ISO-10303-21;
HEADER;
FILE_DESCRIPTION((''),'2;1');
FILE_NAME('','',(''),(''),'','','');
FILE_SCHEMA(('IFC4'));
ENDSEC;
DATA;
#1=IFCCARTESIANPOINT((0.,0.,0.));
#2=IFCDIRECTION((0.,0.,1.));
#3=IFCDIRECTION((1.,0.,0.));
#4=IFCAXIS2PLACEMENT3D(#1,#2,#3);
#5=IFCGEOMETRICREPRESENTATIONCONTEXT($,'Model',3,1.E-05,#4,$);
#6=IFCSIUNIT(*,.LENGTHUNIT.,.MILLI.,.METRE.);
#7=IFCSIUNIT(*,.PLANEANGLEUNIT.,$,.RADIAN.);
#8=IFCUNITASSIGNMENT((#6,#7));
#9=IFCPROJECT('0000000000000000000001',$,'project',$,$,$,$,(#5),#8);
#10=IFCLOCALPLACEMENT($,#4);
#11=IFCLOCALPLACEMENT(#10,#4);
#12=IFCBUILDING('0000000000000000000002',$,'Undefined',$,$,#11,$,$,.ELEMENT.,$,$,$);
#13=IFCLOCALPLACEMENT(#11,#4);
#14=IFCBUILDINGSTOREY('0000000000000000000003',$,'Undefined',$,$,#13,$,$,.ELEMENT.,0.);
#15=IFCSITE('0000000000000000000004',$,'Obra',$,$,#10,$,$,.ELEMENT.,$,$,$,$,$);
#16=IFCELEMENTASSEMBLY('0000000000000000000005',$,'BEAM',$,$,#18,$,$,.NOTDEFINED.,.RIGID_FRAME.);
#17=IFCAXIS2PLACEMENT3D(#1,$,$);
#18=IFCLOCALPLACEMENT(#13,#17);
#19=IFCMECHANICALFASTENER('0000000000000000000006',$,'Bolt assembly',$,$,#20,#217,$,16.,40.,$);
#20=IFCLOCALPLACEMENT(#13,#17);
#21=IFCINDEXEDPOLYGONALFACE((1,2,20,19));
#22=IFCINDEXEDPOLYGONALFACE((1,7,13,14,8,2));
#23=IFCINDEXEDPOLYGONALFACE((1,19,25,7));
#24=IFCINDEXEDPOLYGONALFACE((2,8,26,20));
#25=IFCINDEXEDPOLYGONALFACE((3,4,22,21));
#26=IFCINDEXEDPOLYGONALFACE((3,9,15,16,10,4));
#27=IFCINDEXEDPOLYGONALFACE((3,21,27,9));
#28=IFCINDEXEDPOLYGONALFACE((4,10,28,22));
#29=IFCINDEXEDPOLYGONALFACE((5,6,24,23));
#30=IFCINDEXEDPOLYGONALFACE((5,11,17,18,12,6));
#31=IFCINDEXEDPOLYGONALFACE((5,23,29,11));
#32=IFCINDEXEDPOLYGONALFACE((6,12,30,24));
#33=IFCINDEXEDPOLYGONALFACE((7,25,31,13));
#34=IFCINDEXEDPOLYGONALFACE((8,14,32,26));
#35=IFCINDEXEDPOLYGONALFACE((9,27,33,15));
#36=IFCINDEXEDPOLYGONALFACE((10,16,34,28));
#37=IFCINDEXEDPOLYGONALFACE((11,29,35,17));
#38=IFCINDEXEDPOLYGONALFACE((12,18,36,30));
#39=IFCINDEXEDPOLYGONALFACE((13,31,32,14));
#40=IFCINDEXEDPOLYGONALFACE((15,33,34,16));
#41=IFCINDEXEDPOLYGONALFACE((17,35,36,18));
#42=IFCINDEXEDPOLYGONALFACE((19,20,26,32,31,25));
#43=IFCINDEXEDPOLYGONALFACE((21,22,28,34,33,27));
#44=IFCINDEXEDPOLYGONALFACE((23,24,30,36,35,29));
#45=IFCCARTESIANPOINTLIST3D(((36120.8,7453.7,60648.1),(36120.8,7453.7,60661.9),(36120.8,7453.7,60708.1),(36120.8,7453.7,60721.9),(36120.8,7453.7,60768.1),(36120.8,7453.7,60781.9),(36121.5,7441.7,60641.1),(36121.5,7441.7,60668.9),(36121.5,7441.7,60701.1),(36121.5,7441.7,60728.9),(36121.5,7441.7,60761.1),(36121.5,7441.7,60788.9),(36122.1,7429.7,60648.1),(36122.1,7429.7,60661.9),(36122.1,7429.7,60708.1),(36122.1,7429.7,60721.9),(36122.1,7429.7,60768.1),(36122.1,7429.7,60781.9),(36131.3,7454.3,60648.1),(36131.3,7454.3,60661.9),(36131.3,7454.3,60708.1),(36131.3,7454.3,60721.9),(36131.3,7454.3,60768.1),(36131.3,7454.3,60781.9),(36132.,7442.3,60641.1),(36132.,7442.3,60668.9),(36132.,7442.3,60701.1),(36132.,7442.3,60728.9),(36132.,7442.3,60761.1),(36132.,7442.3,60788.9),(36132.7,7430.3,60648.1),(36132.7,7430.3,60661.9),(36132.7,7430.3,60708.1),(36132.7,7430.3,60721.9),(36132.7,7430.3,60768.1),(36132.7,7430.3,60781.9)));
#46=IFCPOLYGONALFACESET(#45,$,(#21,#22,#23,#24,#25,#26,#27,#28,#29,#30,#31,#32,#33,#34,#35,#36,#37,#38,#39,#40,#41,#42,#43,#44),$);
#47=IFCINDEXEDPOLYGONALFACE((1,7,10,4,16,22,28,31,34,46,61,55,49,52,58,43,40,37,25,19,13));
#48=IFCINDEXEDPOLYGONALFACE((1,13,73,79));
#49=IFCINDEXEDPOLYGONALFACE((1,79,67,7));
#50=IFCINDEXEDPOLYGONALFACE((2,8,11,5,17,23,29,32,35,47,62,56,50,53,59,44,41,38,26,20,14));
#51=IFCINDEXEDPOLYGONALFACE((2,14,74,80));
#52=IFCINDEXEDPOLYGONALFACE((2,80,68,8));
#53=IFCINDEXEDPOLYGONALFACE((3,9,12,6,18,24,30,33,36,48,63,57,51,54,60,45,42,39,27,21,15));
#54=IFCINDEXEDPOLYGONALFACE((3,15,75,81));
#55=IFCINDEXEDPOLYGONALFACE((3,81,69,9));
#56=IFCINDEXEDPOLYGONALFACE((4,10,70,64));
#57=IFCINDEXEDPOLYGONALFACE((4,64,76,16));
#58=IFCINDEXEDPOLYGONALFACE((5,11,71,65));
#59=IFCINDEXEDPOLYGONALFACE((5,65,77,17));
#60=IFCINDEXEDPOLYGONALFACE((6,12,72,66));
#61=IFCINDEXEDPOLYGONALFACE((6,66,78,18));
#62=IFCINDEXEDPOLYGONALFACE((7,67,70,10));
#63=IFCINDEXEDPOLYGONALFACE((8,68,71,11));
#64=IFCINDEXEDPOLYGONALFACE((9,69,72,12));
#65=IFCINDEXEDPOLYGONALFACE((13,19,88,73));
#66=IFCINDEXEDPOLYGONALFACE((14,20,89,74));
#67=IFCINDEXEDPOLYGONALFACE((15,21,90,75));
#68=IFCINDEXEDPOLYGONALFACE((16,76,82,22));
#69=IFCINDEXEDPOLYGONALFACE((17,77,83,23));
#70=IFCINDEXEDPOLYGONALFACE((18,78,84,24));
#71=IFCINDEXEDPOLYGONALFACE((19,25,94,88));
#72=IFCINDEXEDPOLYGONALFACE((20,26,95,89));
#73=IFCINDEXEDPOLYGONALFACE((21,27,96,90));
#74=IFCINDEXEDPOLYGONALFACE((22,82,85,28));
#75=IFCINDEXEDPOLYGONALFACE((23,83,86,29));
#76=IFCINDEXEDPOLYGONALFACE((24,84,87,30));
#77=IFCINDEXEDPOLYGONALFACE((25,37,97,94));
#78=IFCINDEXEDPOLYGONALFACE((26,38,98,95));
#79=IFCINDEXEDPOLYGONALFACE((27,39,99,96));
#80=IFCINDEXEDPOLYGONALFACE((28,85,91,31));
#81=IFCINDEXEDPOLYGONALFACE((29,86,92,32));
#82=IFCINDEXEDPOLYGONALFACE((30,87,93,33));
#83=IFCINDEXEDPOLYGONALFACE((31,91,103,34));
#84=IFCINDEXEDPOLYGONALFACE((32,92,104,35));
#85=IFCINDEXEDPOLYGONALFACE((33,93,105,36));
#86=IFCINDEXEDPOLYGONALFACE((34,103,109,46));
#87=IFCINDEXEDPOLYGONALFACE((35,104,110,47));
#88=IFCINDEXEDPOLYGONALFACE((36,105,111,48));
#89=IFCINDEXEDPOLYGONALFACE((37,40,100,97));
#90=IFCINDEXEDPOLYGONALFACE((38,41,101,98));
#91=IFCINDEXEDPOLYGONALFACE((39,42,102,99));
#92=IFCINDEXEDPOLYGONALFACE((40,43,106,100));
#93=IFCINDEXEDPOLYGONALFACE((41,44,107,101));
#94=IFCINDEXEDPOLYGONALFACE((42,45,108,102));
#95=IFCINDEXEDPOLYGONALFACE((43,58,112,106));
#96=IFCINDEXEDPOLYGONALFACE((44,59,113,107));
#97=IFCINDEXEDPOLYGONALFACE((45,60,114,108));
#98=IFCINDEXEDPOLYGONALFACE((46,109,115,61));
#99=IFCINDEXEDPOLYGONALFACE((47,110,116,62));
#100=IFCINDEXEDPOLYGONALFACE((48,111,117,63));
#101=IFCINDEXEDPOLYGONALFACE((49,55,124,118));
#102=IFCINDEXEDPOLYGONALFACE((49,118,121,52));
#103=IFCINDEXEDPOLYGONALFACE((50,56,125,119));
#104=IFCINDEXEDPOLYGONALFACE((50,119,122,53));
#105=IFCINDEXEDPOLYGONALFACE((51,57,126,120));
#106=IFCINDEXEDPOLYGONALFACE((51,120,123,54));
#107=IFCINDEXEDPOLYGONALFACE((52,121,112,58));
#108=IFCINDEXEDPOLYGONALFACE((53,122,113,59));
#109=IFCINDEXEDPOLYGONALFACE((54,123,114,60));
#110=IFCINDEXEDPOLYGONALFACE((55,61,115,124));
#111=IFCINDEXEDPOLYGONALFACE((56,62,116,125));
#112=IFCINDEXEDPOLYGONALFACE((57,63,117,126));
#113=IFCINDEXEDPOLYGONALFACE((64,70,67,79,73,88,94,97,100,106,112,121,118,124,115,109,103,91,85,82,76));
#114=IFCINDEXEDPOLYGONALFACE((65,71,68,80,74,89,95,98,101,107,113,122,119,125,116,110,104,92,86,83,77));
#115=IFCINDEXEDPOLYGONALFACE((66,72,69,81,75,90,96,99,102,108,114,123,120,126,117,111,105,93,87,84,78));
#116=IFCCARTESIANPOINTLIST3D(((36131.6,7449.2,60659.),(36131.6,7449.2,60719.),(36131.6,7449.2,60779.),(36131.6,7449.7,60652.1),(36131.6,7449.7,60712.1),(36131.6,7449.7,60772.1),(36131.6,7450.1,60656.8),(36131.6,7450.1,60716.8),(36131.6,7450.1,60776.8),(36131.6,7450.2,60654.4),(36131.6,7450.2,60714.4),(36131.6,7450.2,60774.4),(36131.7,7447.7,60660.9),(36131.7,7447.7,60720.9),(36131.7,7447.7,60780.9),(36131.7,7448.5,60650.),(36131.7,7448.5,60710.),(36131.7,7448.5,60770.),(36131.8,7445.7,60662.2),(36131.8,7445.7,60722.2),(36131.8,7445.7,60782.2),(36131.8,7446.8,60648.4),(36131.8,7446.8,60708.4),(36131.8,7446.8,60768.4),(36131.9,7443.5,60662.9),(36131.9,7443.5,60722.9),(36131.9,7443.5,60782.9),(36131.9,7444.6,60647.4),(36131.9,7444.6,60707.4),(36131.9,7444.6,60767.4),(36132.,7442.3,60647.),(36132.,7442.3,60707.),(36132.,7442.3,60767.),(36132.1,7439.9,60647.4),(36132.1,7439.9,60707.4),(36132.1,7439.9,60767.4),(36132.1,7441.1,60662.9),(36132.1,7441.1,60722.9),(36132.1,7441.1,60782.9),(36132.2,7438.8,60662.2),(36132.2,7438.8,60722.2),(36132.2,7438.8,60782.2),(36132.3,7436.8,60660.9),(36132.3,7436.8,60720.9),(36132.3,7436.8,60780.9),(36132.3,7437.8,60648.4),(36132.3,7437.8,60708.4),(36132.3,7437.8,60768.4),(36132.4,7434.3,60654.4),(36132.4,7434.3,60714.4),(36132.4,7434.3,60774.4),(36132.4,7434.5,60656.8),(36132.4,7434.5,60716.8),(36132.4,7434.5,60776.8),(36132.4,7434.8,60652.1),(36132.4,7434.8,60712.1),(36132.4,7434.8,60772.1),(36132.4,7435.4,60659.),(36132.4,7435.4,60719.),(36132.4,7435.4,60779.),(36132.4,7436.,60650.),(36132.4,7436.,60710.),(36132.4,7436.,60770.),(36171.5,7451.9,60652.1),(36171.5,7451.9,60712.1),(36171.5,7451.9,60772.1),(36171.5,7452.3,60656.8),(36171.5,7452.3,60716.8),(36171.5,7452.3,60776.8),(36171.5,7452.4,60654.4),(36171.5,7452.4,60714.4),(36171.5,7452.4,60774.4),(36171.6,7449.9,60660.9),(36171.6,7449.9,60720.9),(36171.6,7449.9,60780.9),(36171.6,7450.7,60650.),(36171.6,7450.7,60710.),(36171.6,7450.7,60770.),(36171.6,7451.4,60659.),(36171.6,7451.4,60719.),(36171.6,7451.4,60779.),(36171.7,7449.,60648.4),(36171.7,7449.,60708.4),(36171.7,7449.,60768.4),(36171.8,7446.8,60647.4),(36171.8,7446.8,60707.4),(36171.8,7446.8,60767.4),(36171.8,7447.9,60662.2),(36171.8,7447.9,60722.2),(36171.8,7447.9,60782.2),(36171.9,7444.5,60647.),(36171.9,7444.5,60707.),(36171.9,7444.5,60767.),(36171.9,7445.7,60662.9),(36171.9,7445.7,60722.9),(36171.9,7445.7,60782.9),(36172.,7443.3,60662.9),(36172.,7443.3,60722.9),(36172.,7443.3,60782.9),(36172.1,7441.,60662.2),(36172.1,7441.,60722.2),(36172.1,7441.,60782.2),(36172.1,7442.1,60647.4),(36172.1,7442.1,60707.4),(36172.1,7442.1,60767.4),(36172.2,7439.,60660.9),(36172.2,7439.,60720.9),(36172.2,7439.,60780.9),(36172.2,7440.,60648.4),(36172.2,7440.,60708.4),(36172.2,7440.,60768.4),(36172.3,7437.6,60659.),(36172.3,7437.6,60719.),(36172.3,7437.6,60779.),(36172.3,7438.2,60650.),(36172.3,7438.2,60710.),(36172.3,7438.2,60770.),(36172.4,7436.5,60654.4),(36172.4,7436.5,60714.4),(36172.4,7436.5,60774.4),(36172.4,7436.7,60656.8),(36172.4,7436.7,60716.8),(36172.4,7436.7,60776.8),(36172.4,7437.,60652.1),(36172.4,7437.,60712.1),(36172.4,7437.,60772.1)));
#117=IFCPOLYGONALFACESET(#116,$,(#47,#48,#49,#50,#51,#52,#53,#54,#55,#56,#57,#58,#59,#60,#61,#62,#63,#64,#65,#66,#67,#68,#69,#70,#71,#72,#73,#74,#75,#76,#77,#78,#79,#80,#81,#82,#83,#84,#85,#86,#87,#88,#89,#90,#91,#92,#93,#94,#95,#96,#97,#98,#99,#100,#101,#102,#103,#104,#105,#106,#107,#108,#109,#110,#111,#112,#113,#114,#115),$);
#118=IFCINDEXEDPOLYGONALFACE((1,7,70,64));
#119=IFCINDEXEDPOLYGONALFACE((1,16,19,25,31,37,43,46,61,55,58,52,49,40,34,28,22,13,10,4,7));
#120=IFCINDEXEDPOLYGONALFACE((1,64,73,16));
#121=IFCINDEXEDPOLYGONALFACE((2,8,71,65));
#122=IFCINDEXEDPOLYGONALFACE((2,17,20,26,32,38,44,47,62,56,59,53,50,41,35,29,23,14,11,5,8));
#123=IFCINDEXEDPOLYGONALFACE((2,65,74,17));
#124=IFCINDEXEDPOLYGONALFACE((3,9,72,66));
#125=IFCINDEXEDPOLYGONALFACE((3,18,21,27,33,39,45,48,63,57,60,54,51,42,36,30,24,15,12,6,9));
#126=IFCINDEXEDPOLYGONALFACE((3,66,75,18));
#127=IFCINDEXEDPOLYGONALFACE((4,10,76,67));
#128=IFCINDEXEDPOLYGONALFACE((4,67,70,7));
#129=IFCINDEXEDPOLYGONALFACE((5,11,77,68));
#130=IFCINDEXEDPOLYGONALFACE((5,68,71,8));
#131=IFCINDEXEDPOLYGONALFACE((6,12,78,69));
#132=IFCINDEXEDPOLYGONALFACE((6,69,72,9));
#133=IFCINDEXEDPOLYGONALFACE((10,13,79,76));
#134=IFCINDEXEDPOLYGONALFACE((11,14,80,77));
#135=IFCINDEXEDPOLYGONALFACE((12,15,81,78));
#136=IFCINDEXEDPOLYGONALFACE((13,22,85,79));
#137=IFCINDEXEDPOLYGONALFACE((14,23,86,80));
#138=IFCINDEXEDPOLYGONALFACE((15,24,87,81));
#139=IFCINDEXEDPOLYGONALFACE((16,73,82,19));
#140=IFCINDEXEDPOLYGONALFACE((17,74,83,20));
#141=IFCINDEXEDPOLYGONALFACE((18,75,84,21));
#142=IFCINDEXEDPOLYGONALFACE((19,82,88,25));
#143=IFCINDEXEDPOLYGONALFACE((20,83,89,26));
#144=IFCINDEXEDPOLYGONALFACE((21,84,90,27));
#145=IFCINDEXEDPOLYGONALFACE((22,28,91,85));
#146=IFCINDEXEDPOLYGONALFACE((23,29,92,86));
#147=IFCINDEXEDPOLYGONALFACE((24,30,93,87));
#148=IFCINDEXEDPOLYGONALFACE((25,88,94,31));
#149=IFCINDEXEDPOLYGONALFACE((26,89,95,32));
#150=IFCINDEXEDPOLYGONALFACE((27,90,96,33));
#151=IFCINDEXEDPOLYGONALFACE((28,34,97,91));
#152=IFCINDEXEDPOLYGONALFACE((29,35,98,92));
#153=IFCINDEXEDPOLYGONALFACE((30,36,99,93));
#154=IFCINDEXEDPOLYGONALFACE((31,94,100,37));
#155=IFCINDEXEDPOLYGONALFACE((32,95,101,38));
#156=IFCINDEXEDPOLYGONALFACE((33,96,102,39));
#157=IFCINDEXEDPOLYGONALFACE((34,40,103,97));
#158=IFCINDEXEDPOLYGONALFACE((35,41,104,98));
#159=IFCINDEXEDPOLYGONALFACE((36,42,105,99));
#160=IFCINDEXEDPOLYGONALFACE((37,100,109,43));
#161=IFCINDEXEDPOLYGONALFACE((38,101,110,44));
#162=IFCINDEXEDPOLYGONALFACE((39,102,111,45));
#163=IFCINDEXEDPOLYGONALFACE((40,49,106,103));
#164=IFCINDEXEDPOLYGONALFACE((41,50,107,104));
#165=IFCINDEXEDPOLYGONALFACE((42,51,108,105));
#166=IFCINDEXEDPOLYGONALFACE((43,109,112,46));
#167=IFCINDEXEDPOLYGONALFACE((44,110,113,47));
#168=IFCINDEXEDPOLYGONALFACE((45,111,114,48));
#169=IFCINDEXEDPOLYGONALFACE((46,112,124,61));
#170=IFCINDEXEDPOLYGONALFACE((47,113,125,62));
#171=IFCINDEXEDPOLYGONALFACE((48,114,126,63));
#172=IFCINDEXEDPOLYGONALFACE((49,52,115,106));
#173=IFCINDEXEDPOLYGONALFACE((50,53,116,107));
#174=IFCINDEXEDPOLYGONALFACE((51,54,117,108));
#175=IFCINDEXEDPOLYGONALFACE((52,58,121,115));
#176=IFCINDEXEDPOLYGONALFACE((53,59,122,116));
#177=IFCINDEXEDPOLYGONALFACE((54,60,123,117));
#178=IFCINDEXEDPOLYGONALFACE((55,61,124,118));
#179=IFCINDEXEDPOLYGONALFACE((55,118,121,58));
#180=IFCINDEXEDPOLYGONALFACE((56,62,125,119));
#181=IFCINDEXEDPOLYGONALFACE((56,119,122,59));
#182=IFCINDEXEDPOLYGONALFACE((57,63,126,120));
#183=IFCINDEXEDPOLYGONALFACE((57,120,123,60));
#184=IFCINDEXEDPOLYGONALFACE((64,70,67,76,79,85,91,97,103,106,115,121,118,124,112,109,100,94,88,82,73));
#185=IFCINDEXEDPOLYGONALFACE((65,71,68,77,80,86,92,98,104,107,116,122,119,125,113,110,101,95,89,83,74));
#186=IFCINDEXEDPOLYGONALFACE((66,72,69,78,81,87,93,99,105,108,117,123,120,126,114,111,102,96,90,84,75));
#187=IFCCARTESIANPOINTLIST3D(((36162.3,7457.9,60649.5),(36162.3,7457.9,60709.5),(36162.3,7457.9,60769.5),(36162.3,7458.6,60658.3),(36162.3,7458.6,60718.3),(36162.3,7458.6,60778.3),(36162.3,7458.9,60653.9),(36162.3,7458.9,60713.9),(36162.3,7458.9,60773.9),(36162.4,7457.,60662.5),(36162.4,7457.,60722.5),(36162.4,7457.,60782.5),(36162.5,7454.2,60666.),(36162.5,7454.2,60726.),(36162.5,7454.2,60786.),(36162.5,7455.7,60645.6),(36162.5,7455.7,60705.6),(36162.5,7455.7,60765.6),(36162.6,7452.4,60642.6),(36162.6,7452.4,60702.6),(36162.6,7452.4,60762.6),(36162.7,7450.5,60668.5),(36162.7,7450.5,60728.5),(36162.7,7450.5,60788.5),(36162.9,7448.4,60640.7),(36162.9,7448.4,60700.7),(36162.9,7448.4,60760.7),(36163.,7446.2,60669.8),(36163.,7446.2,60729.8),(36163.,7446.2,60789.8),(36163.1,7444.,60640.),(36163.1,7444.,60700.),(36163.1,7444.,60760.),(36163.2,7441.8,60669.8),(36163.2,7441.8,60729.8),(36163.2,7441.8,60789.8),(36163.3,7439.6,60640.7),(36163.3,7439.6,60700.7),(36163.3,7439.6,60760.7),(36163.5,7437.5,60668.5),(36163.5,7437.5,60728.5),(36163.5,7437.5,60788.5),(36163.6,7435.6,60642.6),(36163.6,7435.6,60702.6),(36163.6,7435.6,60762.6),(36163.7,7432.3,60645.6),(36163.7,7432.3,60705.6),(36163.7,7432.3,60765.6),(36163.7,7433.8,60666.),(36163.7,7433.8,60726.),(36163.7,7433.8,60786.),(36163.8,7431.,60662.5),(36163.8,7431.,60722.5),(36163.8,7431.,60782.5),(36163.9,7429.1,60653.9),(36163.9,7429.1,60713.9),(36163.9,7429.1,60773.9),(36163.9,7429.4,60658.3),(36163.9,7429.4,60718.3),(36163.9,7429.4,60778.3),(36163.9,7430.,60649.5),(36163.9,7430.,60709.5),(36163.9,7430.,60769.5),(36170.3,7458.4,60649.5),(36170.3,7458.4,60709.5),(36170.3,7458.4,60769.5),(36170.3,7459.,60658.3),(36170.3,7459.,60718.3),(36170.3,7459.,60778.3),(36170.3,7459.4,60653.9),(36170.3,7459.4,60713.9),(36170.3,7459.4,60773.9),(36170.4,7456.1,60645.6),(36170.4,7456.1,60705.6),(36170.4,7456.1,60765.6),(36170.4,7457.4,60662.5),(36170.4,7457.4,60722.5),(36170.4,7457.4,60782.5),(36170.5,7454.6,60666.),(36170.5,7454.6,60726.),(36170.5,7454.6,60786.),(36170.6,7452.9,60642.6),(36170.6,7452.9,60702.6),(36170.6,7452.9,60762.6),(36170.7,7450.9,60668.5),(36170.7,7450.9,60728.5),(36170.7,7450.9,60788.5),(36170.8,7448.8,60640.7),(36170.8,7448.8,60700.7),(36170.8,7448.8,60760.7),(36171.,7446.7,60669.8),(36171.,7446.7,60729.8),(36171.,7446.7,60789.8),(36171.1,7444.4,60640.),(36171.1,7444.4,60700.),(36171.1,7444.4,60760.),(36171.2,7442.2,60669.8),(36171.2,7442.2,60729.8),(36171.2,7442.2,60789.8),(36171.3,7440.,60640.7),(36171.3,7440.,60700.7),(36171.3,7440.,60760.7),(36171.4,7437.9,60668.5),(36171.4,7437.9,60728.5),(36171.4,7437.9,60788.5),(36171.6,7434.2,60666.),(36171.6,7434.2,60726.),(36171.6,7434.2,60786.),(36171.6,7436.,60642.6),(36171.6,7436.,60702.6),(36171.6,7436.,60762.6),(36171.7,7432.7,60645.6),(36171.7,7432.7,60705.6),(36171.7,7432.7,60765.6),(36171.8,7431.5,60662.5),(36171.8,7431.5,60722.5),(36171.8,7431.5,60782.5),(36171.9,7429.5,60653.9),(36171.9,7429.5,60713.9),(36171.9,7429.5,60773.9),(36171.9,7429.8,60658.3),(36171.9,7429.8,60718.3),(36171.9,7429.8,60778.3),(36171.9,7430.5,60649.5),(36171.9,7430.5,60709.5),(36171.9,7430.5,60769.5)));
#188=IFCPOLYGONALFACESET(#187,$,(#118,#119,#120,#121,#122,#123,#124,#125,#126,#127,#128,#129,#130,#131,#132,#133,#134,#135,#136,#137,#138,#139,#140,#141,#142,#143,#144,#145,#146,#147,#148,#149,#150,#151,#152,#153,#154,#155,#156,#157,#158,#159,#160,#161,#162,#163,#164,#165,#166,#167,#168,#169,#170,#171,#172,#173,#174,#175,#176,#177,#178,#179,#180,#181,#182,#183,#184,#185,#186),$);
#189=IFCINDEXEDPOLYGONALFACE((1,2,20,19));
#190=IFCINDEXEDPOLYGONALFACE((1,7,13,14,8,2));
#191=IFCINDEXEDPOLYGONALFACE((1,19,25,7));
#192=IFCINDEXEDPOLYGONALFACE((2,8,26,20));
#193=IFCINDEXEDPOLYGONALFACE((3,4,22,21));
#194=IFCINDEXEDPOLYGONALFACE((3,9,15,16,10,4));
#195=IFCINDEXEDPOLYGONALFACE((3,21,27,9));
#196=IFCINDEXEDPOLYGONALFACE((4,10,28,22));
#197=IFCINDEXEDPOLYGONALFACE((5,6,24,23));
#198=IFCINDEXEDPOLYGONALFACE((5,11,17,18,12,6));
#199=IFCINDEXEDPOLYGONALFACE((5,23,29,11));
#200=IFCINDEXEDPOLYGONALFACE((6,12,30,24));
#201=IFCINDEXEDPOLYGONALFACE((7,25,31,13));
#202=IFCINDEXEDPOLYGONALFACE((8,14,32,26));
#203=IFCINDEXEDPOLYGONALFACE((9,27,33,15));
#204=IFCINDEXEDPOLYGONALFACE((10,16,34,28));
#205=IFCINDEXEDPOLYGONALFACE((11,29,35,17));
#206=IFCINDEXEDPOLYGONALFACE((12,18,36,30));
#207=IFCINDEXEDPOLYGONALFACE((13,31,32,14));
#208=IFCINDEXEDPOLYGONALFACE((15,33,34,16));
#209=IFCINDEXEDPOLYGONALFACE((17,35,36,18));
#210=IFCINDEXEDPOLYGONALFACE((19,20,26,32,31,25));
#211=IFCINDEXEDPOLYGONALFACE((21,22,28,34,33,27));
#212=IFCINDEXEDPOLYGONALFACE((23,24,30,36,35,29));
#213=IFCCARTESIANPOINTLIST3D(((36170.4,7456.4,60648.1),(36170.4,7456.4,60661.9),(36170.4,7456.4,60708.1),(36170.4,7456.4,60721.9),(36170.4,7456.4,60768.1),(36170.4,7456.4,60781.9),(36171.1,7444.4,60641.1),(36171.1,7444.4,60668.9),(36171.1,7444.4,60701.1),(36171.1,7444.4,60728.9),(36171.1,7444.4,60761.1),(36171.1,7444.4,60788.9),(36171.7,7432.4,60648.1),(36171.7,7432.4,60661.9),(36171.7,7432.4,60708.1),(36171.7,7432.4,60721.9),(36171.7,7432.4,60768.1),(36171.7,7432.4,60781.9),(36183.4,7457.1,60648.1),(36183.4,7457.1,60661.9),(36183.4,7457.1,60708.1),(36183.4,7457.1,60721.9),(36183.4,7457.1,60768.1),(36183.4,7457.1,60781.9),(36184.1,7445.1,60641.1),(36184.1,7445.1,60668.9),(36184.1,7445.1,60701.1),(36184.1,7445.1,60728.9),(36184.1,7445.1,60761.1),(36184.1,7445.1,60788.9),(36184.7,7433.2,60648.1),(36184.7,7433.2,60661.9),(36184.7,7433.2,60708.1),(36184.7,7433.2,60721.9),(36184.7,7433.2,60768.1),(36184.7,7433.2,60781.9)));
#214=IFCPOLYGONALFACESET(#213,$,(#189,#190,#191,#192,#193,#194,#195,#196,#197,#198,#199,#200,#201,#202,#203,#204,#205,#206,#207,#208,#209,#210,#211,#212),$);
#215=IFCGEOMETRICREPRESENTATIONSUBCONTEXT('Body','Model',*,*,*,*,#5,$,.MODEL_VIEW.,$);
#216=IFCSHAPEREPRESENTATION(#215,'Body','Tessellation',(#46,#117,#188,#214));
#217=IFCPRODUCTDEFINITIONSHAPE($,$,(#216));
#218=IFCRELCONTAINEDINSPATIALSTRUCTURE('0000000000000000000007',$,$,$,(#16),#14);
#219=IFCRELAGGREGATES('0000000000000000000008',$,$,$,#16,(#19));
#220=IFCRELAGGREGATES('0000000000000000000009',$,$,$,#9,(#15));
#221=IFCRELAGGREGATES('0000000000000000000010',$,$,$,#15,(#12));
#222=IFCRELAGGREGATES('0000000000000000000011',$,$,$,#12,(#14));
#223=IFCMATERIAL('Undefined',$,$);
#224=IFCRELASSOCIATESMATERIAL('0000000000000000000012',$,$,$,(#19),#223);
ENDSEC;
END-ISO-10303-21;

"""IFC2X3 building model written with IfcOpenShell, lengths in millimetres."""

from ifc_helpers import new_model, si_unit, frame, origin_with_axes, origin_2d_with_axis, place, context, subcontext, project, spatial, polyline, circle, outline, extrude, source, transform, mapped, material, element, aggregate, save


model = new_model("IFC2X3")

# Units and contexts
model_context = context("Model", 3, precision=1e-05, world=origin_with_axes())
body_context = subcontext(model_context, "Body", "Model", "MODEL_VIEW")
ifc_project = project(units=[si_unit("LENGTHUNIT", "METRE", prefix="MILLI"), si_unit("PLANEANGLEUNIT", "RADIAN")], contexts=[model_context])

# Site, building, storey
site_placement = place(None, origin_with_axes())
site = spatial("IfcSite", under=ifc_project, at=site_placement, Name="Obra", CompositionType="ELEMENT")
building_placement = place(site_placement, origin_with_axes())
building = spatial("IfcBuilding", under=site, at=building_placement, Name="Undefined", CompositionType="ELEMENT")
storey_placement = place(building_placement, origin_with_axes())
storey = spatial("IfcBuildingStorey", under=building, at=storey_placement, Name="Undefined", CompositionType="ELEMENT", Elevation=0.0)

# Element assembly, mechanical fastener
ifc_material_1 = material(Name="Undefined")
shared_shape_1 = source(origin_with_axes(), body_context, "Body", "SweptSolid", [
    extrude(outline(polyline([(13.9, 0.0), (6.9, 12.0), (-6.9, 12.0), (-13.9, 0.0), (-6.9, -12.0), (6.9, -12.0), (13.9, 0.0)])), frame((0.0, -44.8, 0.0), z_axis=(0.0, 1.0, 0.0), x_axis=(1.0, 0.0, 0.0)), (0.0, 0.0, 1.0), 10.6),
    extrude(circle(Radius=8.0, at=origin_2d_with_axis()), frame((0.0, -34.2, 0.0), z_axis=(0.0, 1.0, 0.0), x_axis=(1.0, 0.0, 0.0)), (0.0, 0.0, 1.0), 40.0),
    extrude(circle(Radius=15.0, at=origin_2d_with_axis()), frame((0.0, -3.1, 0.0), z_axis=(0.0, 1.0, 0.0), x_axis=(1.0, 0.0, 0.0)), (0.0, 0.0, 1.0), 8.0),
    extrude(outline(polyline([(13.9, 0.0), (6.9, 12.0), (-6.9, 12.0), (-13.9, 0.0), (-6.9, -12.0), (6.9, -12.0), (13.9, 0.0)])), frame((0.0, 4.9, 0.0), z_axis=(0.0, 1.0, 0.0), x_axis=(1.0, 0.0, 0.0)), (0.0, 0.0, 1.0), 13.0),
])
assembly_1_placement = place(storey_placement, origin_with_axes())
assembly_1 = element("IfcElementAssembly", 1, at=assembly_1_placement, inside=storey, Name="BEAM", AssemblyPlace="NOTDEFINED", PredefinedType="RIGID_FRAME")
mechanical_fastener_1_placement = place(assembly_1_placement, frame((36163.4, 7494.1, 60835.0), z_axis=(0.055152, -0.998478, 0.0), x_axis=(0.0, 0.0, -1.0)))
mechanical_fastener_1 = element("IfcMechanicalFastener", 2, at=mechanical_fastener_1_placement, material=ifc_material_1, Name="Bolt assembly", NominalDiameter=16.0, NominalLength=40.0, context=body_context, shape_type="MappedRepresentation", body=[
    mapped(shared_shape_1, transform((60.0, 0.0, 50.0))),
    mapped(shared_shape_1, transform((120.0, 0.0, 50.0))),
    mapped(shared_shape_1, transform((180.0, 0.0, 50.0))),
])

aggregate(assembly_1, [mechanical_fastener_1])

save(model, "model.ifc")
